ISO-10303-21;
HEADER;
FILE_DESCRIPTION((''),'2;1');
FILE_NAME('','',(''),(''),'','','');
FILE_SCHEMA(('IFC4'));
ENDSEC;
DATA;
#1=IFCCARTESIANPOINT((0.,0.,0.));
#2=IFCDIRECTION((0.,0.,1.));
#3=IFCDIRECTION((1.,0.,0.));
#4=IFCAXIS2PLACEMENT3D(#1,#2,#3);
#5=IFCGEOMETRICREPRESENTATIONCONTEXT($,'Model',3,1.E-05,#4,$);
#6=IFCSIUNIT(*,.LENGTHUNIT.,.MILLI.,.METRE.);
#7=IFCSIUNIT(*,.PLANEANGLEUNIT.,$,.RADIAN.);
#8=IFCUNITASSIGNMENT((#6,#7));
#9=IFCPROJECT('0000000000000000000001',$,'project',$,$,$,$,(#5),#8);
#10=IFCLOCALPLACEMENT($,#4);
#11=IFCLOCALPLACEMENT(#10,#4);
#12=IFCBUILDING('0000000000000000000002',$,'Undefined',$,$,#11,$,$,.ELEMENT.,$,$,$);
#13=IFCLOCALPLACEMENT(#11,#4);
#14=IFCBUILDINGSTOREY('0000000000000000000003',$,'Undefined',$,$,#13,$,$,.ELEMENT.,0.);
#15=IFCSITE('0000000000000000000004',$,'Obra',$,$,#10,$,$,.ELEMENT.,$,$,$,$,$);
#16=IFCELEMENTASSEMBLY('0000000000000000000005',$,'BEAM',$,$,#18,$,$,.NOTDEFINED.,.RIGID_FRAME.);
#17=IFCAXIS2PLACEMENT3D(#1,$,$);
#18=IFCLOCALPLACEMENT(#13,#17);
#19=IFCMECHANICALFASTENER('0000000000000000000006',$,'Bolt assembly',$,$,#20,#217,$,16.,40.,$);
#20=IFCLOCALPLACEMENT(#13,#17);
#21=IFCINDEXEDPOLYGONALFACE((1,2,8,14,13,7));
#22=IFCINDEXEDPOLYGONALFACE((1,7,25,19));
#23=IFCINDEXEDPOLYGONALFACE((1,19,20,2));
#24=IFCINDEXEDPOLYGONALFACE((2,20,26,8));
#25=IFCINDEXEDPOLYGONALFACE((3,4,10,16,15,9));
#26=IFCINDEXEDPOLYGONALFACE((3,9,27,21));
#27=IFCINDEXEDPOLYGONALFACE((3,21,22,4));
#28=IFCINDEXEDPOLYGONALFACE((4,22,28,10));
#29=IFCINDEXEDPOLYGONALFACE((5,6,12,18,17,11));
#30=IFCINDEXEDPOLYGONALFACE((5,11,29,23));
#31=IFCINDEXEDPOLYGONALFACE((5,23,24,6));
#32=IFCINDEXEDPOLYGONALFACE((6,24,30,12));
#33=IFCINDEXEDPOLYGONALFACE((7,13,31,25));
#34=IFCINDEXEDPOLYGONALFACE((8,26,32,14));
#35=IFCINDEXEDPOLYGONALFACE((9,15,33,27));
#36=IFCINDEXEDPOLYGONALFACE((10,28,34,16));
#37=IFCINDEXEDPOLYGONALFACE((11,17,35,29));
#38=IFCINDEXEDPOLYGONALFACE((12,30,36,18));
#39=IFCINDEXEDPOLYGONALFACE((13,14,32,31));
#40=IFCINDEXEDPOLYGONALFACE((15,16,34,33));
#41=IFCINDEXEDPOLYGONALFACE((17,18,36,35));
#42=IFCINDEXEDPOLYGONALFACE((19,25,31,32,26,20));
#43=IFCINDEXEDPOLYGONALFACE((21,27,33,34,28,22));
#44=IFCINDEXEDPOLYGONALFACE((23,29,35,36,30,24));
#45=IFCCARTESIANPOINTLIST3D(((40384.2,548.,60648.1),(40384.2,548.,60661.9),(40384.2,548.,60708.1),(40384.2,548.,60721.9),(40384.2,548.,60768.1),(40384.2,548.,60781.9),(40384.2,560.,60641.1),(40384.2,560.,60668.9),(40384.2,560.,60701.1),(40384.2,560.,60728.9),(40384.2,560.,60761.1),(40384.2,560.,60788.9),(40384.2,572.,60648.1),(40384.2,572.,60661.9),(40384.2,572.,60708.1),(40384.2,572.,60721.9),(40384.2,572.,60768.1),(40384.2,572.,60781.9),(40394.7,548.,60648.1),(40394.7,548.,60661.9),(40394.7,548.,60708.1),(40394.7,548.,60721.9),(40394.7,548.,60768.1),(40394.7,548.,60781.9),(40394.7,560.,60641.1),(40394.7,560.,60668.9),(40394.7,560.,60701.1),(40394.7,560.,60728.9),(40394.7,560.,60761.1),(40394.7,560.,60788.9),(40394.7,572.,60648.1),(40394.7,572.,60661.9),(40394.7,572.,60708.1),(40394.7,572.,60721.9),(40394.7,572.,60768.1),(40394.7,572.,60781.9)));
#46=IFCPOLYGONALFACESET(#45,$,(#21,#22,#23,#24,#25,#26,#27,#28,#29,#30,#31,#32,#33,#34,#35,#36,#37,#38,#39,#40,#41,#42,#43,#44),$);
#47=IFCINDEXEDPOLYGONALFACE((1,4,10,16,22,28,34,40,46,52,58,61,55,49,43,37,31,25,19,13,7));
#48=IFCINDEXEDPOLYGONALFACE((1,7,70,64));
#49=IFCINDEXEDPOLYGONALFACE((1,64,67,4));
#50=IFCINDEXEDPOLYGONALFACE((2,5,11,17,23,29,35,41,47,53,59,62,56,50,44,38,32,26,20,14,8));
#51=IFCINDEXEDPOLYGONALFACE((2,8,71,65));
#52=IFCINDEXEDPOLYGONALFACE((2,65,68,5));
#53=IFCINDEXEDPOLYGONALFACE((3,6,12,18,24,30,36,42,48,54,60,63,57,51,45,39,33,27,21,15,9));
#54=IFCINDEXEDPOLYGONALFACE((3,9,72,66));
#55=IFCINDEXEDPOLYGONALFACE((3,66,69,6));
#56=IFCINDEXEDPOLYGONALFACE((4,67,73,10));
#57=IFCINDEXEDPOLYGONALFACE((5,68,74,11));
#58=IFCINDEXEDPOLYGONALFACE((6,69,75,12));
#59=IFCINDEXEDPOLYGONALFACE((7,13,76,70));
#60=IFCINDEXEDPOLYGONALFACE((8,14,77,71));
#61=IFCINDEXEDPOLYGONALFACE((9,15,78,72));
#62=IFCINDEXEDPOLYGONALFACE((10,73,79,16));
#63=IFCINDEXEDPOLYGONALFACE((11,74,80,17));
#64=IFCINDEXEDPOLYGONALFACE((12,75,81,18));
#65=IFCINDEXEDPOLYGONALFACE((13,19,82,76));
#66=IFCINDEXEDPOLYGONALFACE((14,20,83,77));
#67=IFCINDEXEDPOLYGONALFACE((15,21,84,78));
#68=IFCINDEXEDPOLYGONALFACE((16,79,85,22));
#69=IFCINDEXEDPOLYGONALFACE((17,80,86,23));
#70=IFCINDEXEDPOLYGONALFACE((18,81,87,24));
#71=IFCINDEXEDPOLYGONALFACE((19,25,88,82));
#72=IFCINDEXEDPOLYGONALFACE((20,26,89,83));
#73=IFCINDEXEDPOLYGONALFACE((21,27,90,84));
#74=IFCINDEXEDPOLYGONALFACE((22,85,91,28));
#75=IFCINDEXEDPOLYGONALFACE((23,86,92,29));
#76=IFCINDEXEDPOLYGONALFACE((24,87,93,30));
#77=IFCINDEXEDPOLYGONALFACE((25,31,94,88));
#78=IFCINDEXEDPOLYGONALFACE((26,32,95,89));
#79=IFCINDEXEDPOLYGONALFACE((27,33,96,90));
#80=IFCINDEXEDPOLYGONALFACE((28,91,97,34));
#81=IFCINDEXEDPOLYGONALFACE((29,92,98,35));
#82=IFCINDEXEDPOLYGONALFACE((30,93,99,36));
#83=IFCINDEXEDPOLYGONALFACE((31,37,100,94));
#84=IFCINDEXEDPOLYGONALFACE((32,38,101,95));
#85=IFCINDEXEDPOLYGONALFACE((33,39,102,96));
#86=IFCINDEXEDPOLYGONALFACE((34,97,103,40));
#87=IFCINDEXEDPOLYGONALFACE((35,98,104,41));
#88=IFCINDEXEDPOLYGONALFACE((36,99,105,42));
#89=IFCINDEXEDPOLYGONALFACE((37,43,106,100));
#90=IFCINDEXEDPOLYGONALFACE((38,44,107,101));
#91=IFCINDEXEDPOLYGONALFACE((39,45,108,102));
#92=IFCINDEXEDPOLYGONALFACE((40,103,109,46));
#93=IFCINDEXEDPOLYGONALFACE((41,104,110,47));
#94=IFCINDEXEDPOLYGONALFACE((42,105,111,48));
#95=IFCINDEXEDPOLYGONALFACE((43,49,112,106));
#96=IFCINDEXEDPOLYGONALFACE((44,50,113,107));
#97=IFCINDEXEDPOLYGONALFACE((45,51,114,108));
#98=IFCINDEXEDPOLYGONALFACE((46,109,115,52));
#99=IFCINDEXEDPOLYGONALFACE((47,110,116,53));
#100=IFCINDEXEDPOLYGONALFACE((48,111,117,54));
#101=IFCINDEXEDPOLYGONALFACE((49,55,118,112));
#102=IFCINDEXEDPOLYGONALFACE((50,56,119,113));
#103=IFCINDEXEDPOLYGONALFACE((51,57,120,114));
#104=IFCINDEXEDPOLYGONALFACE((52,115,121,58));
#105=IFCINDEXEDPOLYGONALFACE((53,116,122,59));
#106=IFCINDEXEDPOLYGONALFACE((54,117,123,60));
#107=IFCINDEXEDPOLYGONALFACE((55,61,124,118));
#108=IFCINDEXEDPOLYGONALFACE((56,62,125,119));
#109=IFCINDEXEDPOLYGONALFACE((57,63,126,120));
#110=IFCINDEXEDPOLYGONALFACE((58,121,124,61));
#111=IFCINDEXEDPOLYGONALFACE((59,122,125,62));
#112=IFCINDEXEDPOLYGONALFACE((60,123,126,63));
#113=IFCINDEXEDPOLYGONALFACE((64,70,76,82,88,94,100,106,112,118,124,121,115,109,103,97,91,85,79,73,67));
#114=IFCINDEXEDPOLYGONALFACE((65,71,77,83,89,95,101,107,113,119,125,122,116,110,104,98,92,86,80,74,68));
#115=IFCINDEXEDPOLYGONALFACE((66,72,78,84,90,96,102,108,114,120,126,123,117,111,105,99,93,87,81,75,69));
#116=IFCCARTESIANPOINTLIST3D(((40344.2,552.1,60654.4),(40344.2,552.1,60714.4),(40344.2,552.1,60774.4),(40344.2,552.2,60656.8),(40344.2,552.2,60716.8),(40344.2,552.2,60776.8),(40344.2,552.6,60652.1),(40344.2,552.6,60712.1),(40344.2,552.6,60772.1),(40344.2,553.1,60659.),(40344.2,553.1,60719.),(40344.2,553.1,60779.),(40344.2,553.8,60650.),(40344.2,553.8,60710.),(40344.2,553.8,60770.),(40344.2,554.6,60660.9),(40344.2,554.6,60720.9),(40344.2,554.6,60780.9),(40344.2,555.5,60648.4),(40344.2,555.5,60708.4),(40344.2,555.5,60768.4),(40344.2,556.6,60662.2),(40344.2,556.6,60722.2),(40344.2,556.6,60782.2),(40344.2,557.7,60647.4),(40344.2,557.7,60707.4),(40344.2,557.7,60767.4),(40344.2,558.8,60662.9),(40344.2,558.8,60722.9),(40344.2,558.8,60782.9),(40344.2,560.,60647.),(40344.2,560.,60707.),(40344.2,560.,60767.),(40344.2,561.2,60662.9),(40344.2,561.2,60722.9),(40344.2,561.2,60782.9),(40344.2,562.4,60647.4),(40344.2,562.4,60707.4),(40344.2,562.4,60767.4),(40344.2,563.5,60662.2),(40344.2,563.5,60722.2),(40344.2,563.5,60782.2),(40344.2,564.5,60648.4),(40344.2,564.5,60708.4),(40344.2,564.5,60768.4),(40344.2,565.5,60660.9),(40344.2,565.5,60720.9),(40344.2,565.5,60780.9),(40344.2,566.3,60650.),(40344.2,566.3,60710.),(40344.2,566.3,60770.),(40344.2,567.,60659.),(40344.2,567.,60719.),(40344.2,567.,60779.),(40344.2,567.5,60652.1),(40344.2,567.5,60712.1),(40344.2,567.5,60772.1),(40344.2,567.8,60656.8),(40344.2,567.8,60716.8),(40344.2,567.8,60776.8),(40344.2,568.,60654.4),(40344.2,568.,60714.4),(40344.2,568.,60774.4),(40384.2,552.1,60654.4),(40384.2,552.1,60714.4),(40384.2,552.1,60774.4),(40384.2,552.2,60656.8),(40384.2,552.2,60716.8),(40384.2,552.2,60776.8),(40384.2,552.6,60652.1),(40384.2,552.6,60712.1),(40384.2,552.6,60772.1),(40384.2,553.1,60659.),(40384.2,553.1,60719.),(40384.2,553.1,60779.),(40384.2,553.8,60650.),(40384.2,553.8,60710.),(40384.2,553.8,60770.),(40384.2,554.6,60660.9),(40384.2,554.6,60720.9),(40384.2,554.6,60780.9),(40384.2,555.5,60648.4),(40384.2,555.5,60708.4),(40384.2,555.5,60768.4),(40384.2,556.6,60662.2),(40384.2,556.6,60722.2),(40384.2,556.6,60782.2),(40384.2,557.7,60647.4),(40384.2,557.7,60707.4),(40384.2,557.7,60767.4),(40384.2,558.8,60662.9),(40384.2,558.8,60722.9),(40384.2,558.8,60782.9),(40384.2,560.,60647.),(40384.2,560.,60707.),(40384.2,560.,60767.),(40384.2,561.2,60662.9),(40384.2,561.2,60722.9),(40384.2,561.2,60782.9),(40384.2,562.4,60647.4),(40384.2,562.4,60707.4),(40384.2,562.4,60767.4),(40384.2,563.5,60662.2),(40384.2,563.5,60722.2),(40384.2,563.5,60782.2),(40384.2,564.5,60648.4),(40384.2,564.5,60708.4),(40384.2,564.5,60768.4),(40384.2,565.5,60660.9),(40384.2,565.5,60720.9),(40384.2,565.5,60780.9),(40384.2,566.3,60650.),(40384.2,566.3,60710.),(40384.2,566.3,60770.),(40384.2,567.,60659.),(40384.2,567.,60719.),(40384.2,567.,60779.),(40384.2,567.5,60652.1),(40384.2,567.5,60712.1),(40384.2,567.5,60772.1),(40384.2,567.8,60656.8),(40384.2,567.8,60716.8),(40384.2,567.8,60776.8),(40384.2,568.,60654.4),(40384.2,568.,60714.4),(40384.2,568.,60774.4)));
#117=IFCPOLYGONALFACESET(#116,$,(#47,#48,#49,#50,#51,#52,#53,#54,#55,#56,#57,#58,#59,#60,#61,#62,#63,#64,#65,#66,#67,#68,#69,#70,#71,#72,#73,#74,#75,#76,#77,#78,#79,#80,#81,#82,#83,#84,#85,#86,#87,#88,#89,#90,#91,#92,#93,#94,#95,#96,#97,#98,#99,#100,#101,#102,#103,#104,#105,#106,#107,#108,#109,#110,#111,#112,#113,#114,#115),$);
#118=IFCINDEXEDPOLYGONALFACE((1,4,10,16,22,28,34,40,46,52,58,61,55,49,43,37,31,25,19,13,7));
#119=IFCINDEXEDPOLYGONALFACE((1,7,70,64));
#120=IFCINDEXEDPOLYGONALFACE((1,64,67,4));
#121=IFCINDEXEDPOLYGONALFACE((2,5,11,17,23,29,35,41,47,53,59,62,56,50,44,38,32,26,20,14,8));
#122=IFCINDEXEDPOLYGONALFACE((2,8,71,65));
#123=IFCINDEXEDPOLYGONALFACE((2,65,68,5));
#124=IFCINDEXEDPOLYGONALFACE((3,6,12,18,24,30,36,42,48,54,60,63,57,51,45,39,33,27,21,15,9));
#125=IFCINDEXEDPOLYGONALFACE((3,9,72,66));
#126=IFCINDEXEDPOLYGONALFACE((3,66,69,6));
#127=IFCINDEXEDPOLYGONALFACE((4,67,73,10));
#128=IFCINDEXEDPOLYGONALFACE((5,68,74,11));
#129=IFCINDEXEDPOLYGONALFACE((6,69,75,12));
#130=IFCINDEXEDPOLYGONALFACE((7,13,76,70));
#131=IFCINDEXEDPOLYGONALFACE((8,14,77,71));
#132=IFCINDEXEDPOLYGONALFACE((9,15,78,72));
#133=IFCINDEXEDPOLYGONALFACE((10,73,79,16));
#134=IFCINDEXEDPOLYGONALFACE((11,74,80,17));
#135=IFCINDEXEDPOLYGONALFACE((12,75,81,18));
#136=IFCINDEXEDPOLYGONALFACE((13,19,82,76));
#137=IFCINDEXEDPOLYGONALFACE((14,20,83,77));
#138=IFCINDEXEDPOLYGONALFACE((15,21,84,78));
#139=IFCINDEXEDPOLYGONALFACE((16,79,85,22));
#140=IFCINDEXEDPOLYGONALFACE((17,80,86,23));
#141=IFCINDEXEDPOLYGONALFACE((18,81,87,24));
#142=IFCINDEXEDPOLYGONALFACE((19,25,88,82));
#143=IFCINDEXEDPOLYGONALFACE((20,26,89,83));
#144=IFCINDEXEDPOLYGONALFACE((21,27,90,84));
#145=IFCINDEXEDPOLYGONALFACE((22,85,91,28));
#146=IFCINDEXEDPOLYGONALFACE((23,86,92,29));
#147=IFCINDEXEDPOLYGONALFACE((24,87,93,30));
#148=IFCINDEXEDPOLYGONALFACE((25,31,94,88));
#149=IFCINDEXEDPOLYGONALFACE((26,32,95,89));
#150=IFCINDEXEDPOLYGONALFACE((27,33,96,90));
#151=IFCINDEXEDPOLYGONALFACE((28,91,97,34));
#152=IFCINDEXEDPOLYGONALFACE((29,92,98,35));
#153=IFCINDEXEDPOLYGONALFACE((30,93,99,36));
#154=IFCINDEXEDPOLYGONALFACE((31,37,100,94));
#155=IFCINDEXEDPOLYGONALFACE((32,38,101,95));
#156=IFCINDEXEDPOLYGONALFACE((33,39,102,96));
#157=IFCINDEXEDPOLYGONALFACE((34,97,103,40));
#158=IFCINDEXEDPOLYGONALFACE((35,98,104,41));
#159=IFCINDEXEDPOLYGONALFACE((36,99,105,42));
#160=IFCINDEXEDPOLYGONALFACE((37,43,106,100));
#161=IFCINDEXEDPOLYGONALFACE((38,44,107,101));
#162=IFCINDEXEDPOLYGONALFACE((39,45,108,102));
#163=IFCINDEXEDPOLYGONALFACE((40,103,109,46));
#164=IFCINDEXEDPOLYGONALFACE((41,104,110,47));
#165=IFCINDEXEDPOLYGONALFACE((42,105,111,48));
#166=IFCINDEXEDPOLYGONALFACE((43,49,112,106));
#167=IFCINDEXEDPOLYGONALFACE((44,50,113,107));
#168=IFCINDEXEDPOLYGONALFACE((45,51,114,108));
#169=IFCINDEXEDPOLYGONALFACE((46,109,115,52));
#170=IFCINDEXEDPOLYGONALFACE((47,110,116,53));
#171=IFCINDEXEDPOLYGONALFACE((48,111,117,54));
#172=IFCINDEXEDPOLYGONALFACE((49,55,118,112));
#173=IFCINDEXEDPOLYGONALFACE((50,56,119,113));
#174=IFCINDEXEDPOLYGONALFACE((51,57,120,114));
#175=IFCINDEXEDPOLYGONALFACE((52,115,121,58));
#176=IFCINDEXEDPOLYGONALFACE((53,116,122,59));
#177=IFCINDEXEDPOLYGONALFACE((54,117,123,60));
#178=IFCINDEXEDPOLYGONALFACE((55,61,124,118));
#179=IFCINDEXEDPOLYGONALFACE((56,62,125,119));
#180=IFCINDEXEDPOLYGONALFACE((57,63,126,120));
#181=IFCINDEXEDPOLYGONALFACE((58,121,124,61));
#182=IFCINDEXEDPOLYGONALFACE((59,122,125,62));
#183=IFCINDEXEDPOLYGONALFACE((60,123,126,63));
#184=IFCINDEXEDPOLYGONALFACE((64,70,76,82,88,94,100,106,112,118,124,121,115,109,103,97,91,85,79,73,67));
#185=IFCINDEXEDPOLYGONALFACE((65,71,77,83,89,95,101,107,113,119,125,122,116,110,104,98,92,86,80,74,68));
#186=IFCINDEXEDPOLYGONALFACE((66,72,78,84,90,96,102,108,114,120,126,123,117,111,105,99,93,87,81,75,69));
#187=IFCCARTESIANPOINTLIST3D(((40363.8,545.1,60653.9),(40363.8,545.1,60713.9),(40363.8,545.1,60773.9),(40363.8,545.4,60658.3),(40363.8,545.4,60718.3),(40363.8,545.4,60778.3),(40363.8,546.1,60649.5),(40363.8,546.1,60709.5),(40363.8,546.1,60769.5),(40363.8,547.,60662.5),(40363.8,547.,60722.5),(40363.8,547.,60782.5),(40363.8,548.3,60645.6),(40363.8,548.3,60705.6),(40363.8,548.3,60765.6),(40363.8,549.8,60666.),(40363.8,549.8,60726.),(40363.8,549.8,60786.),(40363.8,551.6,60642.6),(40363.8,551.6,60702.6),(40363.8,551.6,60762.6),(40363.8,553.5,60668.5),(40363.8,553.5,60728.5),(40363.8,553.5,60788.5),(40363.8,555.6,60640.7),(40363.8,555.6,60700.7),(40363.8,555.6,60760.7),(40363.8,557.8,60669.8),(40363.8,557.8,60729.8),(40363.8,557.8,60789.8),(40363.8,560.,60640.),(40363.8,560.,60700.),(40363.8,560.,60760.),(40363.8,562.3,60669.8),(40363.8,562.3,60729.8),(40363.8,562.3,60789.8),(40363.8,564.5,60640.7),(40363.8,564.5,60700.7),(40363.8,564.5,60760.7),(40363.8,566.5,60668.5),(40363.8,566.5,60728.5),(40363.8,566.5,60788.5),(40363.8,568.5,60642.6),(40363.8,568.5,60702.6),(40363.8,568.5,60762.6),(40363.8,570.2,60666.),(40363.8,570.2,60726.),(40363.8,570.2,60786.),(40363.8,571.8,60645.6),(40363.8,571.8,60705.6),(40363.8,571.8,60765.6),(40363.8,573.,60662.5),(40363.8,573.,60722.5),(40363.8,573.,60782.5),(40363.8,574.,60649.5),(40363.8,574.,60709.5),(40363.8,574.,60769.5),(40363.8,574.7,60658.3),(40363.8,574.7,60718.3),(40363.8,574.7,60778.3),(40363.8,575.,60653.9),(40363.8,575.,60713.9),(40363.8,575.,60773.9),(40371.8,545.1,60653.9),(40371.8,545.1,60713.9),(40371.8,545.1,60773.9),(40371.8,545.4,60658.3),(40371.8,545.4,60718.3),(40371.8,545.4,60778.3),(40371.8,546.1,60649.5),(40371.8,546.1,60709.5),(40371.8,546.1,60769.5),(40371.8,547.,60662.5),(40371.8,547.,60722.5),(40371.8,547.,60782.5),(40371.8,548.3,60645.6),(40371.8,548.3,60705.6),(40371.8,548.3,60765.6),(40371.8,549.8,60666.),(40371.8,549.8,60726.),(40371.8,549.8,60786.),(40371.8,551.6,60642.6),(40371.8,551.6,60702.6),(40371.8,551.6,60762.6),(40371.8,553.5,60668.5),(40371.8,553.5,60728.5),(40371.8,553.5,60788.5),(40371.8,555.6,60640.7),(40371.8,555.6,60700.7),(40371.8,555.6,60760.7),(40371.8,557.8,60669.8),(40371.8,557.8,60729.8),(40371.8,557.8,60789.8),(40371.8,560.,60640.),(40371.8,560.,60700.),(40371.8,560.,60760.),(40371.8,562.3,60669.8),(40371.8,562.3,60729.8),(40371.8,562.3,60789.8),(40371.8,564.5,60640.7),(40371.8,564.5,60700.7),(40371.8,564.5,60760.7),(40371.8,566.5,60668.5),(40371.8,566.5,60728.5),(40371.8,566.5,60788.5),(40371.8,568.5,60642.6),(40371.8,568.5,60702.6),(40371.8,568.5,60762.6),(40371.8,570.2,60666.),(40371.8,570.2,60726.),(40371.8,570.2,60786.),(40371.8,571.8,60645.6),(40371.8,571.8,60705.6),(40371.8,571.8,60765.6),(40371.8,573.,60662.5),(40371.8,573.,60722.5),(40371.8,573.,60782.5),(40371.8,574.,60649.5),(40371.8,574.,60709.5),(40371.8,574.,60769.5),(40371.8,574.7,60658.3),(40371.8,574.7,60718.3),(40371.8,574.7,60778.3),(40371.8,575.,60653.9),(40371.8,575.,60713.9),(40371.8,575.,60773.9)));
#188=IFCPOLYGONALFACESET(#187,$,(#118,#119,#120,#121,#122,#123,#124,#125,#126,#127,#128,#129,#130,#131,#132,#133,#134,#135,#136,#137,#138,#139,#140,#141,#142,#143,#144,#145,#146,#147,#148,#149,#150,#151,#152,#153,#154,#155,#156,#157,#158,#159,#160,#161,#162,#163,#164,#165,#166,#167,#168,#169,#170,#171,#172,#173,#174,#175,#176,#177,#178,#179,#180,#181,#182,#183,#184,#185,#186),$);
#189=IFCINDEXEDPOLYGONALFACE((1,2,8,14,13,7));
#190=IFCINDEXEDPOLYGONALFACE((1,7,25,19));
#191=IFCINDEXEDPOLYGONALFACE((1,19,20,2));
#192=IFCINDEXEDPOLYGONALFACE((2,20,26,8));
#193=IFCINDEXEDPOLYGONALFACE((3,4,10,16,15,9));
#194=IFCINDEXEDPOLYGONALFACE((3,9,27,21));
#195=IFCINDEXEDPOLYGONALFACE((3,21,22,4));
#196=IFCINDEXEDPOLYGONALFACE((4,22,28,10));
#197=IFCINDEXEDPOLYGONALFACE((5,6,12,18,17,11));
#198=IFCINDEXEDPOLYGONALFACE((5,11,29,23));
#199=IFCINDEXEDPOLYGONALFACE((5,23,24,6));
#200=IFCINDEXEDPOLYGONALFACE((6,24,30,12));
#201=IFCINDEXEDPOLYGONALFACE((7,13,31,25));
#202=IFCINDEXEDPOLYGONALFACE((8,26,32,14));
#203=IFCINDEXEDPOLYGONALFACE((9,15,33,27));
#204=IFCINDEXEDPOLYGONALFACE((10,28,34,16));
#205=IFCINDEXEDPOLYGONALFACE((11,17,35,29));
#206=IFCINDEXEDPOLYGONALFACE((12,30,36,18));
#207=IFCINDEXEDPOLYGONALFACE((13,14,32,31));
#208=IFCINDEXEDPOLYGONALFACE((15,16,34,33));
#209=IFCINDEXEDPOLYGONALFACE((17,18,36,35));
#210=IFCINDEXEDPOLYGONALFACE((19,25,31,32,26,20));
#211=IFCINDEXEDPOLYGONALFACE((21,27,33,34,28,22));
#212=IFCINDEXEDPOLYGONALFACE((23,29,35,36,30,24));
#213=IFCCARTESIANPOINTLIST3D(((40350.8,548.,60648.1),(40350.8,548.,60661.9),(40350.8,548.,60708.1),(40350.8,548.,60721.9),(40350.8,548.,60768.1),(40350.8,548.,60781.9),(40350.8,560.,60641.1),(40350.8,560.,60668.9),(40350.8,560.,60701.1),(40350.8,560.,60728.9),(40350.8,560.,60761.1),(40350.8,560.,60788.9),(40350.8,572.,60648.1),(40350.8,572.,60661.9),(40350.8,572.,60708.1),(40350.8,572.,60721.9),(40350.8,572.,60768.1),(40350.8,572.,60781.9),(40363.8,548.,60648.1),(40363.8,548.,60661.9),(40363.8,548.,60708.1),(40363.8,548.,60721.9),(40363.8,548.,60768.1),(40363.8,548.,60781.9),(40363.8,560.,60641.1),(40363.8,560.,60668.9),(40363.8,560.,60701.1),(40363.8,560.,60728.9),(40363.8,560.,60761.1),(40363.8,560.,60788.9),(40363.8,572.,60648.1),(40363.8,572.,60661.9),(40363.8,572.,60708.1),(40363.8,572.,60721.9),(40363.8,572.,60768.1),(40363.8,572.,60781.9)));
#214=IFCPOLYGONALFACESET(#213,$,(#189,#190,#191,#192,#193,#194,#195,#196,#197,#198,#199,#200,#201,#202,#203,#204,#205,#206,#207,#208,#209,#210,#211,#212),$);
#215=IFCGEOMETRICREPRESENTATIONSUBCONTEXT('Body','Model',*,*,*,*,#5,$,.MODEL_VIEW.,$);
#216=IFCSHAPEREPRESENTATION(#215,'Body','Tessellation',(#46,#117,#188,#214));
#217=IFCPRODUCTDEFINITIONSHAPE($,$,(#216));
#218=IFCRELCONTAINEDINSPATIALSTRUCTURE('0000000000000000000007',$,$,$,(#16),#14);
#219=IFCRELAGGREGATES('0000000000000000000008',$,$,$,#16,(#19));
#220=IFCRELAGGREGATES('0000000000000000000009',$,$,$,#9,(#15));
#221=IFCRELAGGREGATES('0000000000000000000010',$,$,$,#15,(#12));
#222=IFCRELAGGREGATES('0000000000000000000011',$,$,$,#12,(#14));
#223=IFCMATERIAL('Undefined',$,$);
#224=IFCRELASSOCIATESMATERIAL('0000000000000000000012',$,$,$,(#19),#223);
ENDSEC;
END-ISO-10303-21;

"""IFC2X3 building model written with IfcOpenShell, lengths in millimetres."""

from ifc_helpers import new_model, si_unit, frame, origin_with_axes, origin_2d_with_axis, place, context, subcontext, project, spatial, polyline, circle, outline, extrude, source, transform, mapped, material, element, aggregate, save


model = new_model("IFC2X3")

# Units and contexts
model_context = context("Model", 3, precision=1e-05, world=origin_with_axes())
body_context = subcontext(model_context, "Body", "Model", "MODEL_VIEW")
ifc_project = project(units=[si_unit("LENGTHUNIT", "METRE", prefix="MILLI"), si_unit("PLANEANGLEUNIT", "RADIAN")], contexts=[model_context])

# Site, building, storey
site_placement = place(None, origin_with_axes())
site = spatial("IfcSite", under=ifc_project, at=site_placement, Name="Obra", CompositionType="ELEMENT")
building_placement = place(site_placement, origin_with_axes())
building = spatial("IfcBuilding", under=site, at=building_placement, Name="Undefined", CompositionType="ELEMENT")
storey_placement = place(building_placement, origin_with_axes())
storey = spatial("IfcBuildingStorey", under=building, at=storey_placement, Name="Undefined", CompositionType="ELEMENT", Elevation=0.0)

# Element assembly
assembly_1_placement = place(storey_placement, origin_with_axes())
assembly_1 = element("IfcElementAssembly", 1, at=assembly_1_placement, inside=storey, Name="BEAM", AssemblyPlace="NOTDEFINED", PredefinedType="RIGID_FRAME")
ifc_material_1 = material(Name="Undefined")

# Mechanical fastener
shared_shape_1 = source(origin_with_axes(), body_context, "Body", "SweptSolid", [
    extrude(outline(polyline([(13.9, 0.0), (6.9, 12.0), (-6.9, 12.0), (-13.9, 0.0), (-6.9, -12.0), (6.9, -12.0), (13.9, 0.0)])), frame((0.0, -19.7, 0.0), z_axis=(0.0, 1.0, 0.0), x_axis=(1.0, 0.0, 0.0)), (0.0, 0.0, 1.0), 10.6),
    extrude(circle(Radius=8.0, at=origin_2d_with_axis()), frame((0.0, -9.1, 0.0), z_axis=(0.0, 1.0, 0.0), x_axis=(1.0, 0.0, 0.0)), (0.0, 0.0, 1.0), 40.0),
    extrude(circle(Radius=15.0, at=origin_2d_with_axis()), frame((0.0, 3.3, 0.0), z_axis=(0.0, 1.0, 0.0), x_axis=(1.0, 0.0, 0.0)), (0.0, 0.0, 1.0), 8.0),
    extrude(outline(polyline([(13.9, 0.0), (6.9, 12.0), (-6.9, 12.0), (-13.9, 0.0), (-6.9, -12.0), (6.9, -12.0), (13.9, 0.0)])), frame((0.0, 11.3, 0.0), z_axis=(0.0, 1.0, 0.0), x_axis=(1.0, 0.0, 0.0)), (0.0, 0.0, 1.0), 13.0),
])
mechanical_fastener_1_placement = place(assembly_1_placement, frame((40375.1, 510.0, 60835.0), z_axis=(-0.000002, 1.0, 0.0), x_axis=(0.0, 0.0, -1.0)))
mechanical_fastener_1 = element("IfcMechanicalFastener", 2, at=mechanical_fastener_1_placement, material=ifc_material_1, Name="Bolt assembly", NominalDiameter=16.0, NominalLength=40.0, context=body_context, shape_type="MappedRepresentation", body=[
    mapped(shared_shape_1, transform((60.0, 0.0, 50.0))),
    mapped(shared_shape_1, transform((120.0, 0.0, 50.0))),
    mapped(shared_shape_1, transform((180.0, 0.0, 50.0))),
])
aggregate(assembly_1, [mechanical_fastener_1])

save(model, "model.ifc")
